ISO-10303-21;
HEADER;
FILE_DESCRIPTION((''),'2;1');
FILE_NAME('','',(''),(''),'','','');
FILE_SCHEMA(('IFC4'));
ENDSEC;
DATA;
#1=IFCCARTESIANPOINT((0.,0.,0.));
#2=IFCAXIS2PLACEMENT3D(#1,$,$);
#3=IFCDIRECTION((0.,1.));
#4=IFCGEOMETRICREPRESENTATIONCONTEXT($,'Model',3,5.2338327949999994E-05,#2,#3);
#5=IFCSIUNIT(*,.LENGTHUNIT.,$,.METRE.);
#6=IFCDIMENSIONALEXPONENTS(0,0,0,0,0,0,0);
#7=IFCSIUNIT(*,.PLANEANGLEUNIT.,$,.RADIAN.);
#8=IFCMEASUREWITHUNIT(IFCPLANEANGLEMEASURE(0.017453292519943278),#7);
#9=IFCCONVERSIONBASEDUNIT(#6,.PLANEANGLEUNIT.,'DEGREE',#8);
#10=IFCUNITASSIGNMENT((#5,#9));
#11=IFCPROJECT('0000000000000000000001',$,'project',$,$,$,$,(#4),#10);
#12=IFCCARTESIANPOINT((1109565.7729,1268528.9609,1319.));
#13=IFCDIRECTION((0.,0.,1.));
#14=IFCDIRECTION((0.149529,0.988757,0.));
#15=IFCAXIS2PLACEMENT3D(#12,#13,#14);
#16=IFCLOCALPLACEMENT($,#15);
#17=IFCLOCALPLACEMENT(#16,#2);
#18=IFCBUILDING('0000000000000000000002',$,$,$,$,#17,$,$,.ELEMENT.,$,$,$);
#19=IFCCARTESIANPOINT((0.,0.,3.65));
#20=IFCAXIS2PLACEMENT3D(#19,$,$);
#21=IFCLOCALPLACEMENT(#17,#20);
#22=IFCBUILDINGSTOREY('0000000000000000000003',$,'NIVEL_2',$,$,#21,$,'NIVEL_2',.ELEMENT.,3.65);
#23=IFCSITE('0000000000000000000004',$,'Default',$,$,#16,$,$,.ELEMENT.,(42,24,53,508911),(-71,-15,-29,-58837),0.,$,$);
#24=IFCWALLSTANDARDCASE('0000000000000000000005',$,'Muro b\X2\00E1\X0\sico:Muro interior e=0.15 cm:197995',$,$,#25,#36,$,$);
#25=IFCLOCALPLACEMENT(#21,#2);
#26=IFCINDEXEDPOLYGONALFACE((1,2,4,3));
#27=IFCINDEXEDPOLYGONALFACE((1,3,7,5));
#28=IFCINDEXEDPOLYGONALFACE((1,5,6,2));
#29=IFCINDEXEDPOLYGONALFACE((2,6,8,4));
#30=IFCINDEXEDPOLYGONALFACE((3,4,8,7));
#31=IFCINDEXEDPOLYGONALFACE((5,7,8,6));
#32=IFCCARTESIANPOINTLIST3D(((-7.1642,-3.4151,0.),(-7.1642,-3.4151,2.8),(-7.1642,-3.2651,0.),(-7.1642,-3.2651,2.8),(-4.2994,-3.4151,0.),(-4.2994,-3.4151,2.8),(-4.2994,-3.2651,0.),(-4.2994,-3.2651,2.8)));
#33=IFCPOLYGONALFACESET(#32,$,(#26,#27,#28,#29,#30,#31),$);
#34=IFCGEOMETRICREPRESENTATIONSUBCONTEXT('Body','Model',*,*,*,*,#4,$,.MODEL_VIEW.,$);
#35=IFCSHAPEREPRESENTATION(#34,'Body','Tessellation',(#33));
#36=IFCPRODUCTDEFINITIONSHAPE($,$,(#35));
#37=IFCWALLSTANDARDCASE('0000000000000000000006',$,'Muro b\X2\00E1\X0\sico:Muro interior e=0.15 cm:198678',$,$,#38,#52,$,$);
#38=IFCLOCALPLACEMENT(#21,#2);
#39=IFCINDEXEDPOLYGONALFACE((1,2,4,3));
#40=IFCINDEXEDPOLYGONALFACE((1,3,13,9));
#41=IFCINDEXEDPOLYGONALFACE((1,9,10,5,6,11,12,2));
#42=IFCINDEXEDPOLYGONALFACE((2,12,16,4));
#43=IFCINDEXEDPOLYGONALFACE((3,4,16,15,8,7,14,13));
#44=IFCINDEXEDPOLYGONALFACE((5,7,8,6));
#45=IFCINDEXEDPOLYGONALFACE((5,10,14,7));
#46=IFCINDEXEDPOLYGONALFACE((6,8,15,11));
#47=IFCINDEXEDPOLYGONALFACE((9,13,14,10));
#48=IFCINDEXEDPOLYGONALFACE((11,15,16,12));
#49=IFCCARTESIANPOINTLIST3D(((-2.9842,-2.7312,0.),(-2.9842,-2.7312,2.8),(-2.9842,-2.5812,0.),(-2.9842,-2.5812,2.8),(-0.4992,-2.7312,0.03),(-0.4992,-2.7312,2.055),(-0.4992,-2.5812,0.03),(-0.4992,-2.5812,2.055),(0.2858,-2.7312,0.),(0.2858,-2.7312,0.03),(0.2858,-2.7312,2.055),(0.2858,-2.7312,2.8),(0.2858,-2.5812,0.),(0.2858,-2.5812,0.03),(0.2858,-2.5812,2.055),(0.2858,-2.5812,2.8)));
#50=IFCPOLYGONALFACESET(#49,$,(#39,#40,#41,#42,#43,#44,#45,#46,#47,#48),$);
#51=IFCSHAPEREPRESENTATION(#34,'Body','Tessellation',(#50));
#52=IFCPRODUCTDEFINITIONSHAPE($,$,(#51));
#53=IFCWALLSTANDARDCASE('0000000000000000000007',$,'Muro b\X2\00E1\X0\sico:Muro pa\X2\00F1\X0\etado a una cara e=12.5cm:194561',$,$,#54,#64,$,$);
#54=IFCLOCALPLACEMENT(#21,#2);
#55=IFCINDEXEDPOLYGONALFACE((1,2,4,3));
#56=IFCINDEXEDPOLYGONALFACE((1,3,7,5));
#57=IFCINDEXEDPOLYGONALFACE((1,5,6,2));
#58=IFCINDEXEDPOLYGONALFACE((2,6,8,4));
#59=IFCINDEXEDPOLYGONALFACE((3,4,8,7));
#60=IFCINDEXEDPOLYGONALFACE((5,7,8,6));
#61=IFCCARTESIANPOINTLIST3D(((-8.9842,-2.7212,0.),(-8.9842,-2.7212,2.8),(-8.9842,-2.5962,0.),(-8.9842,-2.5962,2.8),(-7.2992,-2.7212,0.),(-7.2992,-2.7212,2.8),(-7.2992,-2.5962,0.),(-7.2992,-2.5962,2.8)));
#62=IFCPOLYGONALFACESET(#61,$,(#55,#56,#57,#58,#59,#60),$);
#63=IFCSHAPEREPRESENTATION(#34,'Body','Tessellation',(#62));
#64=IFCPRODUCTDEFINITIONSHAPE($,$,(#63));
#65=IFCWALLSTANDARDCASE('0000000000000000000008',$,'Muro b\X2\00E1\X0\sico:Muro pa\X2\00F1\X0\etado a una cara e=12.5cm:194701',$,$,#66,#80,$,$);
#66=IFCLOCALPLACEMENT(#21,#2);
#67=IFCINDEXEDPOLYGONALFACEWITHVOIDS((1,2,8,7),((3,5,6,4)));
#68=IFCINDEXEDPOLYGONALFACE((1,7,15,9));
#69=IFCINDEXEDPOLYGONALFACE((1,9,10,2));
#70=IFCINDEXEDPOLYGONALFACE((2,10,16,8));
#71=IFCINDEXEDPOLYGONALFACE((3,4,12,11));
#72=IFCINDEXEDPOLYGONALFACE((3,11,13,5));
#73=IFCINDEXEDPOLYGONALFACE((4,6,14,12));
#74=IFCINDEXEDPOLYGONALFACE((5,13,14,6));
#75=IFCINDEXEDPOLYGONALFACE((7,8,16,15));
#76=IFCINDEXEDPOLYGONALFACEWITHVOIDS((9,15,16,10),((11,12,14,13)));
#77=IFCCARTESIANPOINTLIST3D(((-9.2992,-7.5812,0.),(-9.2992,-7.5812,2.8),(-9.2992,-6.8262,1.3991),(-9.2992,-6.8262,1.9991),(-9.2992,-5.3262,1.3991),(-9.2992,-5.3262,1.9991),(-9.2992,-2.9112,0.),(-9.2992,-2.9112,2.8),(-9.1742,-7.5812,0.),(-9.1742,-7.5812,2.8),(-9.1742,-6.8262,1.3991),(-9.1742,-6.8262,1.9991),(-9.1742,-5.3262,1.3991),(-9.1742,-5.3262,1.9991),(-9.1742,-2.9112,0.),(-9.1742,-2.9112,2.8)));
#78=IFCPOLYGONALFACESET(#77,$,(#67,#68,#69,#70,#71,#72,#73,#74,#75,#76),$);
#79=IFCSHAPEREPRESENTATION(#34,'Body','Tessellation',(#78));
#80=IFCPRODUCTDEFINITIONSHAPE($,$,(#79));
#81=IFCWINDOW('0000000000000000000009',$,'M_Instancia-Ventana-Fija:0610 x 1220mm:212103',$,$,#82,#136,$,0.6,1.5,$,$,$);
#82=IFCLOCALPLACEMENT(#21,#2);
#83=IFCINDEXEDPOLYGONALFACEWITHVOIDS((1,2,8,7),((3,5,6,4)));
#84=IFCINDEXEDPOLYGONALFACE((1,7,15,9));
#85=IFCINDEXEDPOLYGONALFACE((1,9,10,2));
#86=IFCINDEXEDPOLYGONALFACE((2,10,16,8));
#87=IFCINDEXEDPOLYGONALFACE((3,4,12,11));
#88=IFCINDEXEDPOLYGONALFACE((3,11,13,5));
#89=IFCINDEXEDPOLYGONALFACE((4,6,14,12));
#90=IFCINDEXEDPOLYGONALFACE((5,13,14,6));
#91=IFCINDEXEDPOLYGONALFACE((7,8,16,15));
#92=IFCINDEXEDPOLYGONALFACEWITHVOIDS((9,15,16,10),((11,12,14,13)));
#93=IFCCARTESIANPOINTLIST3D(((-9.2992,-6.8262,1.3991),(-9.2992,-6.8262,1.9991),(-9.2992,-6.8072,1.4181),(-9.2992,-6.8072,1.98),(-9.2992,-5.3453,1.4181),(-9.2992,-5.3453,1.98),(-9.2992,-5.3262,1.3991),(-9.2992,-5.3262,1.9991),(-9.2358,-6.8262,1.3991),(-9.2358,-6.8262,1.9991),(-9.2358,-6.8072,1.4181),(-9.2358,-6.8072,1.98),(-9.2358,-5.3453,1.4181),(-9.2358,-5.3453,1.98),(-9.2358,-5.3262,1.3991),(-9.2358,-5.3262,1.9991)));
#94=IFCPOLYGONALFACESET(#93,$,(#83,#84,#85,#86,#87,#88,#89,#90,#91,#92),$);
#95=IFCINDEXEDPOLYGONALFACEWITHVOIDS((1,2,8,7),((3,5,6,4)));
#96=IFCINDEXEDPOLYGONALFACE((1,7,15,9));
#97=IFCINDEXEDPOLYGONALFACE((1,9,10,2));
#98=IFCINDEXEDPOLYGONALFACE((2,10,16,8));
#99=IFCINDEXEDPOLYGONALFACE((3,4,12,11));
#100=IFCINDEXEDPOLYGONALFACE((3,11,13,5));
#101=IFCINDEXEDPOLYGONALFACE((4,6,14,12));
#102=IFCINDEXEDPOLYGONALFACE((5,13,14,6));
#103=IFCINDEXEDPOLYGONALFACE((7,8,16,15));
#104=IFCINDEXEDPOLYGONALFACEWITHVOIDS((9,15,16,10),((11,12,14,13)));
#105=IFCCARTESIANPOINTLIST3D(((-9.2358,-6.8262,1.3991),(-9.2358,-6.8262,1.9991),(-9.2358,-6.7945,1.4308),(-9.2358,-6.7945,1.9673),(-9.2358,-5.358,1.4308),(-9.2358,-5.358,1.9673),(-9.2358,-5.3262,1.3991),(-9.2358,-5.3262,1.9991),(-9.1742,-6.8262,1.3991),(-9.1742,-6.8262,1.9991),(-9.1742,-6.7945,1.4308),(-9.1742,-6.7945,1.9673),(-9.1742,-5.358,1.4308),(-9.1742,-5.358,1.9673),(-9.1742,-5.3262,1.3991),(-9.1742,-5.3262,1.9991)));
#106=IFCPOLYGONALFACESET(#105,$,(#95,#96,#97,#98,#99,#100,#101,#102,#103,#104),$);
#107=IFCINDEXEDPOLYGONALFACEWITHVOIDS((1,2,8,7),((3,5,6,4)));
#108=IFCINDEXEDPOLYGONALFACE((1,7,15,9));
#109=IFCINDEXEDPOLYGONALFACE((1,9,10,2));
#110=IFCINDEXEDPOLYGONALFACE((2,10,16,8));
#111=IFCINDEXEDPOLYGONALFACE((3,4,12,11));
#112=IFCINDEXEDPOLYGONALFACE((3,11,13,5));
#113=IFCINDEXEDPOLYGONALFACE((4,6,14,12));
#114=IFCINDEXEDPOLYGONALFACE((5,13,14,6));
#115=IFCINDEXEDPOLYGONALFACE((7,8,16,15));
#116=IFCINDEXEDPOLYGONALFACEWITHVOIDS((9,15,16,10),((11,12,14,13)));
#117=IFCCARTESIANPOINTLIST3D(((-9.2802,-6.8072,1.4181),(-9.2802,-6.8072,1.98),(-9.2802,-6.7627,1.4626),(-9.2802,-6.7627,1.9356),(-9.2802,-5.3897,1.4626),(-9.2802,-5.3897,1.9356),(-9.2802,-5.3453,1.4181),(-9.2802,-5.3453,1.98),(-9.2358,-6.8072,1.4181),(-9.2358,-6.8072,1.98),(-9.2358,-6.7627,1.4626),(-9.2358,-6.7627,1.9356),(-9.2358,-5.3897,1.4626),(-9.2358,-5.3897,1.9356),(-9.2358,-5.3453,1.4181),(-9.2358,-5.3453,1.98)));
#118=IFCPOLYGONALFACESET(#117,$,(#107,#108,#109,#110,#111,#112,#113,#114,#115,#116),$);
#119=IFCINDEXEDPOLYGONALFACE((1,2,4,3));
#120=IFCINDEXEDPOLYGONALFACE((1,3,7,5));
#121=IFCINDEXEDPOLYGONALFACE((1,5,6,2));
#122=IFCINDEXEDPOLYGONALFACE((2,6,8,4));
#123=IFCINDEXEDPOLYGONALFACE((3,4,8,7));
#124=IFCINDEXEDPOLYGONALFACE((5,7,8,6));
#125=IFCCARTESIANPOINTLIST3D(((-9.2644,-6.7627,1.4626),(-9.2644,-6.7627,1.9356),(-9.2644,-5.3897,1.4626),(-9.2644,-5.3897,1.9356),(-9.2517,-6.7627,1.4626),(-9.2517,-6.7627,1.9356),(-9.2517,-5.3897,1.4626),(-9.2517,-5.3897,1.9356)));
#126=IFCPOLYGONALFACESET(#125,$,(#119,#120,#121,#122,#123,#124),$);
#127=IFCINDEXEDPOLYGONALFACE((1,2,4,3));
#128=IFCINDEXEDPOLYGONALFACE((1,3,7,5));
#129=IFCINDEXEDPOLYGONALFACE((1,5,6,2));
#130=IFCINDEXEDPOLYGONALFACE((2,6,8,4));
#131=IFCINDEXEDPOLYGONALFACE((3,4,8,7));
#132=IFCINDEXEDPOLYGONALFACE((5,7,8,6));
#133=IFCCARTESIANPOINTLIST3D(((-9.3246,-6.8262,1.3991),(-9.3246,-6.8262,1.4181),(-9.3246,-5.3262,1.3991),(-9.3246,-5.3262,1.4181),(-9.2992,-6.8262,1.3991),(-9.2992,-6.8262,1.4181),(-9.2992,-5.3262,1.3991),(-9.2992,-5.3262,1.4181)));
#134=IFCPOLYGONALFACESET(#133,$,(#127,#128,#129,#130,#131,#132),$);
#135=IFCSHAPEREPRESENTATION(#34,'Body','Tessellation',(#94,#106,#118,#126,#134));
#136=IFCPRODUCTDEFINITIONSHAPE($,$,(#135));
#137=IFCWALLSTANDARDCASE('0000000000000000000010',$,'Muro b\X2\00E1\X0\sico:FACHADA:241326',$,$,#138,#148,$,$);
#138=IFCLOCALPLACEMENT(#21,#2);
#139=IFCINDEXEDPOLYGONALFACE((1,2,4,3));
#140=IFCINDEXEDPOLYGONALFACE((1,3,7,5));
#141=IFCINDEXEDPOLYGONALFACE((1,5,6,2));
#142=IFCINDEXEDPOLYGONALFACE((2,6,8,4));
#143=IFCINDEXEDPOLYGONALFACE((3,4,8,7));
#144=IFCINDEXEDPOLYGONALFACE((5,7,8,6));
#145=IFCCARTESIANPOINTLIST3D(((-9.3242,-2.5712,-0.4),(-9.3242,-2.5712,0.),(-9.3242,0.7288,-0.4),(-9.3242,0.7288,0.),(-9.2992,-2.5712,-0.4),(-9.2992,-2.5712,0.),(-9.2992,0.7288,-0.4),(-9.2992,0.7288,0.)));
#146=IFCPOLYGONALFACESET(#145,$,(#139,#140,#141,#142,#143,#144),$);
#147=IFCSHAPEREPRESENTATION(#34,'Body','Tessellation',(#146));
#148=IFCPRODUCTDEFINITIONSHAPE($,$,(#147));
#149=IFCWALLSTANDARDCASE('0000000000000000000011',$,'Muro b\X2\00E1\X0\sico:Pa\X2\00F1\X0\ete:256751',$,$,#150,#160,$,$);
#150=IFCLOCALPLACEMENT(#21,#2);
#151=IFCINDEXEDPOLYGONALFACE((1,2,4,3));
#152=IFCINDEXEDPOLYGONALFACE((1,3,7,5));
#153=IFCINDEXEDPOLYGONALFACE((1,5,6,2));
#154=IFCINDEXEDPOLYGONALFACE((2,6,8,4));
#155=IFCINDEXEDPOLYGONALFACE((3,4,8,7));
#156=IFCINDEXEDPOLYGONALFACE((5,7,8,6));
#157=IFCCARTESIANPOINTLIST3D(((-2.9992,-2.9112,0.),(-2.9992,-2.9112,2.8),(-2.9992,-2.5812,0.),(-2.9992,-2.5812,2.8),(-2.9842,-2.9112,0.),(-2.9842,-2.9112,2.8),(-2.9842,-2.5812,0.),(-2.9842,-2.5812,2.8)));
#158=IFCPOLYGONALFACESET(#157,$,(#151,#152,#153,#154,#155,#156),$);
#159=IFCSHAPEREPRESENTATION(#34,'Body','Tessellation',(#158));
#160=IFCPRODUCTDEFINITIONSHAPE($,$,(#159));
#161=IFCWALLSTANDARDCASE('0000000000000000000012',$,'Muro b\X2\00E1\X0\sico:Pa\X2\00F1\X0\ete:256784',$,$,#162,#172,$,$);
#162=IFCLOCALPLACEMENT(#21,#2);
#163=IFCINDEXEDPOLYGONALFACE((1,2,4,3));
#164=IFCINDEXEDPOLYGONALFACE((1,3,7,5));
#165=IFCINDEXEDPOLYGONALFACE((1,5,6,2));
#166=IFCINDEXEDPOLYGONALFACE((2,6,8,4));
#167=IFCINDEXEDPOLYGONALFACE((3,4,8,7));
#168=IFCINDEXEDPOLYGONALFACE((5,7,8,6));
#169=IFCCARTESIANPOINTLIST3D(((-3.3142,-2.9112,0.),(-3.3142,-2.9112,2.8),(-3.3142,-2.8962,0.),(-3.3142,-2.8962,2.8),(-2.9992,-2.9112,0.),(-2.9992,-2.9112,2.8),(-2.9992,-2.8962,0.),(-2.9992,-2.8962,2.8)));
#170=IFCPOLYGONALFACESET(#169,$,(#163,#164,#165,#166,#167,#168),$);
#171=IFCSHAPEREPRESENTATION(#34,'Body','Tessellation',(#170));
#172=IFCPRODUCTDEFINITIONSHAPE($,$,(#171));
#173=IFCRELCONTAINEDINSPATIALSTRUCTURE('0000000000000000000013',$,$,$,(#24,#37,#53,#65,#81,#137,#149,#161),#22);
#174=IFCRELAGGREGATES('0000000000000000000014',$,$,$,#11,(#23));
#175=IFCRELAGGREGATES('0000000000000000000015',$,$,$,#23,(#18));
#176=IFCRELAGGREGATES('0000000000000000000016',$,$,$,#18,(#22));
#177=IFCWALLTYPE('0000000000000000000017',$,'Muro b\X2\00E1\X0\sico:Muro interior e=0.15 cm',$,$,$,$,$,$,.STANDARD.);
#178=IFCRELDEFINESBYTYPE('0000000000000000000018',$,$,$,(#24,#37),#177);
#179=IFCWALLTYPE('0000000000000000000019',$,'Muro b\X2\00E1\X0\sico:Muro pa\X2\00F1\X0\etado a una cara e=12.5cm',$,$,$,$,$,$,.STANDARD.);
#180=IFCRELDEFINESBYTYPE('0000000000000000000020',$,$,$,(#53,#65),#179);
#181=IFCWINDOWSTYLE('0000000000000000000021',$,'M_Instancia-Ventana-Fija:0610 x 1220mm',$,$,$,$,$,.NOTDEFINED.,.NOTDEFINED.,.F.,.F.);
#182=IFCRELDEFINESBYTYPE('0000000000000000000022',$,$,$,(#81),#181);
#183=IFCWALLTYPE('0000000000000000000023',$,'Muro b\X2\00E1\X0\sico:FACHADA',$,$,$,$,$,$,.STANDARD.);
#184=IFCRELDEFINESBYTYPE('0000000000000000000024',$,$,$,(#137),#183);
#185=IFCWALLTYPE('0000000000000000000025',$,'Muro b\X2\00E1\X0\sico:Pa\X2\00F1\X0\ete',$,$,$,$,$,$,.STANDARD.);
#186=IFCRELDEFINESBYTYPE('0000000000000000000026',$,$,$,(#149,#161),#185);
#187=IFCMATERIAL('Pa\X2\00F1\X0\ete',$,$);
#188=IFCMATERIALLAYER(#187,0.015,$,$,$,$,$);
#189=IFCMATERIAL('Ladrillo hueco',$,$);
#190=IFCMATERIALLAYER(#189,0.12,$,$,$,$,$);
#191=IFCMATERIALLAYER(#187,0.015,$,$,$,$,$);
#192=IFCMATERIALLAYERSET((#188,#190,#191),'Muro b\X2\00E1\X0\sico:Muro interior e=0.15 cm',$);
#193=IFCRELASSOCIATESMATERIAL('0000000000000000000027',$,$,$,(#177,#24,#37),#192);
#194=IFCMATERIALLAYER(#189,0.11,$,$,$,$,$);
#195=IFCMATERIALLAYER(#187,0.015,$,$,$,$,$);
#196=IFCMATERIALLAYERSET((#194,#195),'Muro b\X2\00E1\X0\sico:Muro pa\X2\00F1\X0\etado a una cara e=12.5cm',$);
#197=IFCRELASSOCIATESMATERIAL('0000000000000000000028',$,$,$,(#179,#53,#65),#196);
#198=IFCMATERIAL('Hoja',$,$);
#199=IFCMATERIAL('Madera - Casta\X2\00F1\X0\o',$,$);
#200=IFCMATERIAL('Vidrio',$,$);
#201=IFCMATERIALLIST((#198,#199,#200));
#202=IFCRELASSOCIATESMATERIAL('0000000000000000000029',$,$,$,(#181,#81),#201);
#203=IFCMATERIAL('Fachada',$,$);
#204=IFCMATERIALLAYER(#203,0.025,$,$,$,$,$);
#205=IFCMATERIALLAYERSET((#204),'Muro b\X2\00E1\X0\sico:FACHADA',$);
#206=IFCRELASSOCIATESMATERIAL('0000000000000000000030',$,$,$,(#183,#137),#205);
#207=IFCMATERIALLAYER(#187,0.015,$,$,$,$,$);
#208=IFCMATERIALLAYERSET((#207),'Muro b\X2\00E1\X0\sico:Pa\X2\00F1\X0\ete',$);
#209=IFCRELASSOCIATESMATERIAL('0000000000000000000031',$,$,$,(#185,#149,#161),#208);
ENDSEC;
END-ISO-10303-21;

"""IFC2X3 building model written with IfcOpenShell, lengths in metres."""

from ifc_helpers import new_model, entity, si_unit, converted_unit, direction, frame, frame_2d, origin, origin_2d_with_axis, place, context, subcontext, project, spatial, polyline, rectangle, outline, extrude, source, transform, mapped, material, material_list, layer, layer_set, layer_usage, type_object, type_shapes, element, fill, save


model = new_model("IFC2X3")

# Units and contexts
model_context = context("Model", 3, precision=5.2338327949999994e-05, world=origin(), true_north=direction((0.0, 1.0)))
body_context = subcontext(model_context, "Body", "Model", "MODEL_VIEW")
ifc_project = project(units=[si_unit("LENGTHUNIT", "METRE"), converted_unit("PLANEANGLEUNIT", "DEGREE", entity("IfcPlaneAngleMeasure", 0.017453292519943278), si_unit("PLANEANGLEUNIT", "RADIAN"), dimensions=[0, 0, 0, 0, 0, 0, 0])], contexts=[model_context])

# Site, building, storey
site_placement = place(None, frame((1109565.7729, 1268528.9609, 1319.0), z_axis=(0.0, 0.0, 1.0), x_axis=(0.149529, 0.988757, 0.0)))
site = spatial("IfcSite", under=ifc_project, at=site_placement, Name="Default", CompositionType="ELEMENT", RefLatitude=(42, 24, 53, 508911), RefLongitude=(-71, -15, -29, -58837), RefElevation=0.0)
building_placement = place(site_placement, origin())
building = spatial("IfcBuilding", under=site, at=building_placement, CompositionType="ELEMENT")
storey_placement = place(building_placement, frame((0.0, 0.0, 3.65)))
storey = spatial("IfcBuildingStorey", under=building, at=storey_placement, Name="NIVEL_2", LongName="NIVEL_2", CompositionType="ELEMENT", Elevation=3.65)

# Wall
ifc_material_1 = material(Name="Pañete")
ifc_layer_1 = layer(ifc_material_1, 0.015)
ifc_material_2 = material(Name="Ladrillo hueco")
ifc_layer_2 = layer(ifc_material_2, 0.12)
ifc_layer_3 = layer(ifc_material_1, 0.015)
ifc_layer_set_1 = layer_set([ifc_layer_1, ifc_layer_2, ifc_layer_3], Name="Muro básico:Muro interior e=0.15 cm")
ifc_layer_usage_1 = layer_usage(ifc_layer_set_1, "AXIS2", "NEGATIVE", 0.075)
wall_type_1 = type_object("IfcWallType", Name="Muro básico:Muro interior e=0.15 cm", PredefinedType="STANDARD", material=ifc_layer_set_1)
wall_1_placement = place(storey_placement, frame((-4.2994, -3.3401, 0.0), z_axis=(0.0, 0.0, 1.0), x_axis=(-1.0, 0.0, 0.0)))
element("IfcWallStandardCase", 1, at=wall_1_placement, inside=storey, type_object=wall_type_1, material=ifc_layer_usage_1, Name="Muro básico:Muro interior e=0.15 cm:197995", context=body_context, shape_type="SweptSolid", body=[
    extrude(rectangle(XDim=2.8649, YDim=0.15, at=frame_2d((1.4324, 0.0), x_axis=(-1.0, 0.0))), origin(), (0.0, 0.0, 1.0), 2.8),
])

# Wall, opening
ifc_layer_usage_2 = layer_usage(ifc_layer_set_1, "AXIS2", "NEGATIVE", 0.075)
wall_2_placement = place(storey_placement, frame((-2.9842, -2.6562, 0.0)))
wall_2 = element("IfcWallStandardCase", 2, at=wall_2_placement, inside=storey, type_object=wall_type_1, material=ifc_layer_usage_2, Name="Muro básico:Muro interior e=0.15 cm:198678", context=body_context, shape_type="SweptSolid", body=[
    extrude(rectangle(XDim=3.27, YDim=0.15, at=frame_2d((1.635, 0.0), x_axis=(-1.0, 0.0))), origin(), (0.0, 0.0, 1.0), 2.8),
])
opening_1_placement = place(wall_2_placement, frame((3.285, 0.075, 0.03)))
element("IfcOpeningElement", 3, at=opening_1_placement, cuts=wall_2, ObjectType="Opening", context=body_context, shape_type="SweptSolid", body=[
    extrude(rectangle(XDim=2.025, YDim=0.8, at=frame_2d((1.0125, 0.4), x_axis=(1.0, 0.0))), frame((0.0, 0.0, 0.0), z_axis=(0.0, -1.0, 0.0), x_axis=(0.0, 0.0, 1.0)), (0.0, 0.0, 1.0), 0.15),
])

# Wall
ifc_layer_4 = layer(ifc_material_2, 0.11)
ifc_layer_5 = layer(ifc_material_1, 0.015)
ifc_layer_set_2 = layer_set([ifc_layer_4, ifc_layer_5], Name="Muro básico:Muro pañetado a una cara e=12.5cm")
ifc_layer_usage_3 = layer_usage(ifc_layer_set_2, "AXIS2", "POSITIVE", -0.0625)
wall_type_2 = type_object("IfcWallType", Name="Muro básico:Muro pañetado a una cara e=12.5cm", PredefinedType="STANDARD", material=ifc_layer_set_2)
wall_3_placement = place(storey_placement, frame((-7.2992, -2.6587, 0.0), z_axis=(0.0, 0.0, 1.0), x_axis=(-1.0, 0.0, 0.0)))
element("IfcWallStandardCase", 4, at=wall_3_placement, inside=storey, type_object=wall_type_2, material=ifc_layer_usage_3, Name="Muro básico:Muro pañetado a una cara e=12.5cm:194561", context=body_context, shape_type="SweptSolid", body=[
    extrude(rectangle(XDim=1.685, YDim=0.125, at=frame_2d((0.8425, 0.0), x_axis=(-1.0, 0.0))), origin(), (0.0, 0.0, 1.0), 2.8),
])

# Wall, opening, window
ifc_layer_usage_4 = layer_usage(ifc_layer_set_2, "AXIS2", "POSITIVE", -0.0625)
wall_4_placement = place(storey_placement, frame((-9.2367, -2.9112, 0.0), z_axis=(0.0, 0.0, 1.0), x_axis=(0.0, -1.0, 0.0)))
wall_4 = element("IfcWallStandardCase", 5, at=wall_4_placement, inside=storey, type_object=wall_type_2, material=ifc_layer_usage_4, Name="Muro básico:Muro pañetado a una cara e=12.5cm:194701", context=body_context, shape_type="SweptSolid", body=[
    extrude(rectangle(XDim=4.67, YDim=0.125, at=frame_2d((2.335, 0.0), x_axis=(-1.0, 0.0))), origin(), (0.0, 0.0, 1.0), 2.8),
])
opening_2_placement = place(wall_4_placement, frame((3.915, 0.0625, 1.3991)))
opening_2 = element("IfcOpeningElement", 6, at=opening_2_placement, cuts=wall_4, ObjectType="Opening", context=body_context, shape_type="SweptSolid", body=[
    extrude(rectangle(XDim=0.6, YDim=1.5, at=frame_2d((0.3, 0.75), x_axis=(-1.0, 0.0))), frame((0.0, 0.0, 0.0), z_axis=(0.0, -1.0, 0.0), x_axis=(0.0, 0.0, 1.0)), (0.0, 0.0, 1.0), 0.125),
])
ifc_material_3 = material(Name="Hoja")
ifc_material_4 = material(Name="Madera - Castaño")
ifc_material_5 = material(Name="Vidrio")
ifc_material_list = material_list([ifc_material_3, ifc_material_4, ifc_material_5])
window_style = type_object("IfcWindowStyle", Name="M_Instancia-Ventana-Fija:0610 x 1220mm", ConstructionType="NOTDEFINED", OperationType="NOTDEFINED", ParameterTakesPrecedence=False, Sizeable=False, material=ifc_material_list)
shared_shape = source(origin(), body_context, "Body", "SweptSolid", [
    extrude(outline(polyline([(-0.3, -0.75), (0.3, -0.75), (0.3, 0.75), (-0.3, 0.75), (-0.3, -0.75)]), holes=[polyline([(-0.2809, -0.7309), (-0.2809, 0.731), (0.281, 0.731), (0.281, -0.7309), (-0.2809, -0.7309)])]), frame((0.75, 0.0616, 0.3), z_axis=(0.0, 1.0, 0.0), x_axis=(0.0, 0.0, -1.0)), (0.0, 0.0, 1.0), 0.0635),
    extrude(outline(polyline([(-0.75, -0.3), (0.75, -0.3), (0.75, 0.3), (-0.75, 0.3), (-0.75, -0.3)]), holes=[polyline([(-0.7183, -0.2682), (-0.7183, 0.2683), (0.7182, 0.2683), (0.7182, -0.2682), (-0.7183, -0.2682)])]), frame((0.75, 0.0, 0.3), z_axis=(0.0, 1.0, 0.0), x_axis=(1.0, 0.0, 0.0)), (0.0, 0.0, 1.0), 0.0616),
    extrude(outline(polyline([(-0.7309, -0.281), (0.7309, -0.281), (0.7309, 0.281), (-0.7309, 0.281), (-0.7309, -0.281)]), holes=[polyline([(-0.6865, -0.2365), (-0.6865, 0.2365), (0.6865, 0.2365), (0.6865, -0.2365), (-0.6865, -0.2365)])]), frame((0.75, 0.0616, 0.3), z_axis=(0.0, 1.0, 0.0), x_axis=(1.0, 0.0, 0.0)), (0.0, 0.0, 1.0), 0.0444),
    extrude(rectangle(XDim=0.0127, YDim=1.373, at=origin_2d_with_axis()), frame((0.75, 0.0838, 0.0635), z_axis=(0.0, 0.0, 1.0), x_axis=(0.0, 1.0, 0.0)), (0.0, 0.0, 1.0), 0.473),
    extrude(rectangle(XDim=0.0254, YDim=1.5, at=origin_2d_with_axis()), frame((0.75, 0.1377, 0.0), z_axis=(0.0, 0.0, 1.0), x_axis=(0.0, -1.0, 0.0)), (0.0, 0.0, 1.0), 0.019),
])
type_shapes(window_style, [shared_shape])
window_placement = place(opening_2_placement, frame((0.0, 0.0, 0.0), z_axis=(0.0, 0.0, 1.0), x_axis=(-1.0, 0.0, 0.0)))
window = element("IfcWindow", 7, at=window_placement, inside=storey, type_object=window_style, material=ifc_material_list, Name="M_Instancia-Ventana-Fija:0610 x 1220mm:212103", OverallHeight=0.6, OverallWidth=1.5, context=body_context, shape_type="MappedRepresentation", body=[
    mapped(shared_shape, transform((0.0, 0.0, 0.0), scale=1.0)),
])
fill(opening_2, window)

# Walls
ifc_material_6 = material(Name="Fachada")
ifc_layer_6 = layer(ifc_material_6, 0.025)
ifc_layer_set_3 = layer_set([ifc_layer_6], Name="Muro básico:FACHADA")
ifc_layer_usage_5 = layer_usage(ifc_layer_set_3, "AXIS2", "NEGATIVE", 0.0125)
wall_type_3 = type_object("IfcWallType", Name="Muro básico:FACHADA", PredefinedType="STANDARD", material=ifc_layer_set_3)
wall_5_placement = place(storey_placement, frame((-9.3117, -2.5712, -0.4), z_axis=(0.0, 0.0, 1.0), x_axis=(0.0, 1.0, 0.0)))
element("IfcWallStandardCase", 8, at=wall_5_placement, inside=storey, type_object=wall_type_3, material=ifc_layer_usage_5, Name="Muro básico:FACHADA:241326", context=body_context, shape_type="SweptSolid", body=[
    extrude(rectangle(XDim=3.3, YDim=0.025, at=frame_2d((1.65, 0.0), x_axis=(-1.0, 0.0))), origin(), (0.0, 0.0, 1.0), 0.4),
])
ifc_layer_7 = layer(ifc_material_1, 0.015)
ifc_layer_set_4 = layer_set([ifc_layer_7], Name="Muro básico:Pañete")
ifc_layer_usage_6 = layer_usage(ifc_layer_set_4, "AXIS2", "NEGATIVE", 0.0075)
wall_type_4 = type_object("IfcWallType", Name="Muro básico:Pañete", PredefinedType="STANDARD", material=ifc_layer_set_4)
wall_6_placement = place(storey_placement, frame((-2.9917, -2.5812, 0.0), z_axis=(0.0, 0.0, 1.0), x_axis=(0.0, -1.0, 0.0)))
element("IfcWallStandardCase", 9, at=wall_6_placement, inside=storey, type_object=wall_type_4, material=ifc_layer_usage_6, Name="Muro básico:Pañete:256751", context=body_context, shape_type="SweptSolid", body=[
    extrude(rectangle(XDim=0.33, YDim=0.015, at=frame_2d((0.165, 0.0), x_axis=(-1.0, 0.0))), origin(), (0.0, 0.0, 1.0), 2.8),
])
ifc_layer_usage_7 = layer_usage(ifc_layer_set_4, "AXIS2", "NEGATIVE", 0.0075)
wall_7_placement = place(storey_placement, frame((-2.9992, -2.9037, 0.0), z_axis=(0.0, 0.0, 1.0), x_axis=(-1.0, 0.0, 0.0)))
element("IfcWallStandardCase", 10, at=wall_7_placement, inside=storey, type_object=wall_type_4, material=ifc_layer_usage_7, Name="Muro básico:Pañete:256784", context=body_context, shape_type="SweptSolid", body=[
    extrude(rectangle(XDim=0.315, YDim=0.015, at=frame_2d((0.1575, 0.0), x_axis=(-1.0, 0.0))), origin(), (0.0, 0.0, 1.0), 2.8),
])

save(model, "model.ifc")
